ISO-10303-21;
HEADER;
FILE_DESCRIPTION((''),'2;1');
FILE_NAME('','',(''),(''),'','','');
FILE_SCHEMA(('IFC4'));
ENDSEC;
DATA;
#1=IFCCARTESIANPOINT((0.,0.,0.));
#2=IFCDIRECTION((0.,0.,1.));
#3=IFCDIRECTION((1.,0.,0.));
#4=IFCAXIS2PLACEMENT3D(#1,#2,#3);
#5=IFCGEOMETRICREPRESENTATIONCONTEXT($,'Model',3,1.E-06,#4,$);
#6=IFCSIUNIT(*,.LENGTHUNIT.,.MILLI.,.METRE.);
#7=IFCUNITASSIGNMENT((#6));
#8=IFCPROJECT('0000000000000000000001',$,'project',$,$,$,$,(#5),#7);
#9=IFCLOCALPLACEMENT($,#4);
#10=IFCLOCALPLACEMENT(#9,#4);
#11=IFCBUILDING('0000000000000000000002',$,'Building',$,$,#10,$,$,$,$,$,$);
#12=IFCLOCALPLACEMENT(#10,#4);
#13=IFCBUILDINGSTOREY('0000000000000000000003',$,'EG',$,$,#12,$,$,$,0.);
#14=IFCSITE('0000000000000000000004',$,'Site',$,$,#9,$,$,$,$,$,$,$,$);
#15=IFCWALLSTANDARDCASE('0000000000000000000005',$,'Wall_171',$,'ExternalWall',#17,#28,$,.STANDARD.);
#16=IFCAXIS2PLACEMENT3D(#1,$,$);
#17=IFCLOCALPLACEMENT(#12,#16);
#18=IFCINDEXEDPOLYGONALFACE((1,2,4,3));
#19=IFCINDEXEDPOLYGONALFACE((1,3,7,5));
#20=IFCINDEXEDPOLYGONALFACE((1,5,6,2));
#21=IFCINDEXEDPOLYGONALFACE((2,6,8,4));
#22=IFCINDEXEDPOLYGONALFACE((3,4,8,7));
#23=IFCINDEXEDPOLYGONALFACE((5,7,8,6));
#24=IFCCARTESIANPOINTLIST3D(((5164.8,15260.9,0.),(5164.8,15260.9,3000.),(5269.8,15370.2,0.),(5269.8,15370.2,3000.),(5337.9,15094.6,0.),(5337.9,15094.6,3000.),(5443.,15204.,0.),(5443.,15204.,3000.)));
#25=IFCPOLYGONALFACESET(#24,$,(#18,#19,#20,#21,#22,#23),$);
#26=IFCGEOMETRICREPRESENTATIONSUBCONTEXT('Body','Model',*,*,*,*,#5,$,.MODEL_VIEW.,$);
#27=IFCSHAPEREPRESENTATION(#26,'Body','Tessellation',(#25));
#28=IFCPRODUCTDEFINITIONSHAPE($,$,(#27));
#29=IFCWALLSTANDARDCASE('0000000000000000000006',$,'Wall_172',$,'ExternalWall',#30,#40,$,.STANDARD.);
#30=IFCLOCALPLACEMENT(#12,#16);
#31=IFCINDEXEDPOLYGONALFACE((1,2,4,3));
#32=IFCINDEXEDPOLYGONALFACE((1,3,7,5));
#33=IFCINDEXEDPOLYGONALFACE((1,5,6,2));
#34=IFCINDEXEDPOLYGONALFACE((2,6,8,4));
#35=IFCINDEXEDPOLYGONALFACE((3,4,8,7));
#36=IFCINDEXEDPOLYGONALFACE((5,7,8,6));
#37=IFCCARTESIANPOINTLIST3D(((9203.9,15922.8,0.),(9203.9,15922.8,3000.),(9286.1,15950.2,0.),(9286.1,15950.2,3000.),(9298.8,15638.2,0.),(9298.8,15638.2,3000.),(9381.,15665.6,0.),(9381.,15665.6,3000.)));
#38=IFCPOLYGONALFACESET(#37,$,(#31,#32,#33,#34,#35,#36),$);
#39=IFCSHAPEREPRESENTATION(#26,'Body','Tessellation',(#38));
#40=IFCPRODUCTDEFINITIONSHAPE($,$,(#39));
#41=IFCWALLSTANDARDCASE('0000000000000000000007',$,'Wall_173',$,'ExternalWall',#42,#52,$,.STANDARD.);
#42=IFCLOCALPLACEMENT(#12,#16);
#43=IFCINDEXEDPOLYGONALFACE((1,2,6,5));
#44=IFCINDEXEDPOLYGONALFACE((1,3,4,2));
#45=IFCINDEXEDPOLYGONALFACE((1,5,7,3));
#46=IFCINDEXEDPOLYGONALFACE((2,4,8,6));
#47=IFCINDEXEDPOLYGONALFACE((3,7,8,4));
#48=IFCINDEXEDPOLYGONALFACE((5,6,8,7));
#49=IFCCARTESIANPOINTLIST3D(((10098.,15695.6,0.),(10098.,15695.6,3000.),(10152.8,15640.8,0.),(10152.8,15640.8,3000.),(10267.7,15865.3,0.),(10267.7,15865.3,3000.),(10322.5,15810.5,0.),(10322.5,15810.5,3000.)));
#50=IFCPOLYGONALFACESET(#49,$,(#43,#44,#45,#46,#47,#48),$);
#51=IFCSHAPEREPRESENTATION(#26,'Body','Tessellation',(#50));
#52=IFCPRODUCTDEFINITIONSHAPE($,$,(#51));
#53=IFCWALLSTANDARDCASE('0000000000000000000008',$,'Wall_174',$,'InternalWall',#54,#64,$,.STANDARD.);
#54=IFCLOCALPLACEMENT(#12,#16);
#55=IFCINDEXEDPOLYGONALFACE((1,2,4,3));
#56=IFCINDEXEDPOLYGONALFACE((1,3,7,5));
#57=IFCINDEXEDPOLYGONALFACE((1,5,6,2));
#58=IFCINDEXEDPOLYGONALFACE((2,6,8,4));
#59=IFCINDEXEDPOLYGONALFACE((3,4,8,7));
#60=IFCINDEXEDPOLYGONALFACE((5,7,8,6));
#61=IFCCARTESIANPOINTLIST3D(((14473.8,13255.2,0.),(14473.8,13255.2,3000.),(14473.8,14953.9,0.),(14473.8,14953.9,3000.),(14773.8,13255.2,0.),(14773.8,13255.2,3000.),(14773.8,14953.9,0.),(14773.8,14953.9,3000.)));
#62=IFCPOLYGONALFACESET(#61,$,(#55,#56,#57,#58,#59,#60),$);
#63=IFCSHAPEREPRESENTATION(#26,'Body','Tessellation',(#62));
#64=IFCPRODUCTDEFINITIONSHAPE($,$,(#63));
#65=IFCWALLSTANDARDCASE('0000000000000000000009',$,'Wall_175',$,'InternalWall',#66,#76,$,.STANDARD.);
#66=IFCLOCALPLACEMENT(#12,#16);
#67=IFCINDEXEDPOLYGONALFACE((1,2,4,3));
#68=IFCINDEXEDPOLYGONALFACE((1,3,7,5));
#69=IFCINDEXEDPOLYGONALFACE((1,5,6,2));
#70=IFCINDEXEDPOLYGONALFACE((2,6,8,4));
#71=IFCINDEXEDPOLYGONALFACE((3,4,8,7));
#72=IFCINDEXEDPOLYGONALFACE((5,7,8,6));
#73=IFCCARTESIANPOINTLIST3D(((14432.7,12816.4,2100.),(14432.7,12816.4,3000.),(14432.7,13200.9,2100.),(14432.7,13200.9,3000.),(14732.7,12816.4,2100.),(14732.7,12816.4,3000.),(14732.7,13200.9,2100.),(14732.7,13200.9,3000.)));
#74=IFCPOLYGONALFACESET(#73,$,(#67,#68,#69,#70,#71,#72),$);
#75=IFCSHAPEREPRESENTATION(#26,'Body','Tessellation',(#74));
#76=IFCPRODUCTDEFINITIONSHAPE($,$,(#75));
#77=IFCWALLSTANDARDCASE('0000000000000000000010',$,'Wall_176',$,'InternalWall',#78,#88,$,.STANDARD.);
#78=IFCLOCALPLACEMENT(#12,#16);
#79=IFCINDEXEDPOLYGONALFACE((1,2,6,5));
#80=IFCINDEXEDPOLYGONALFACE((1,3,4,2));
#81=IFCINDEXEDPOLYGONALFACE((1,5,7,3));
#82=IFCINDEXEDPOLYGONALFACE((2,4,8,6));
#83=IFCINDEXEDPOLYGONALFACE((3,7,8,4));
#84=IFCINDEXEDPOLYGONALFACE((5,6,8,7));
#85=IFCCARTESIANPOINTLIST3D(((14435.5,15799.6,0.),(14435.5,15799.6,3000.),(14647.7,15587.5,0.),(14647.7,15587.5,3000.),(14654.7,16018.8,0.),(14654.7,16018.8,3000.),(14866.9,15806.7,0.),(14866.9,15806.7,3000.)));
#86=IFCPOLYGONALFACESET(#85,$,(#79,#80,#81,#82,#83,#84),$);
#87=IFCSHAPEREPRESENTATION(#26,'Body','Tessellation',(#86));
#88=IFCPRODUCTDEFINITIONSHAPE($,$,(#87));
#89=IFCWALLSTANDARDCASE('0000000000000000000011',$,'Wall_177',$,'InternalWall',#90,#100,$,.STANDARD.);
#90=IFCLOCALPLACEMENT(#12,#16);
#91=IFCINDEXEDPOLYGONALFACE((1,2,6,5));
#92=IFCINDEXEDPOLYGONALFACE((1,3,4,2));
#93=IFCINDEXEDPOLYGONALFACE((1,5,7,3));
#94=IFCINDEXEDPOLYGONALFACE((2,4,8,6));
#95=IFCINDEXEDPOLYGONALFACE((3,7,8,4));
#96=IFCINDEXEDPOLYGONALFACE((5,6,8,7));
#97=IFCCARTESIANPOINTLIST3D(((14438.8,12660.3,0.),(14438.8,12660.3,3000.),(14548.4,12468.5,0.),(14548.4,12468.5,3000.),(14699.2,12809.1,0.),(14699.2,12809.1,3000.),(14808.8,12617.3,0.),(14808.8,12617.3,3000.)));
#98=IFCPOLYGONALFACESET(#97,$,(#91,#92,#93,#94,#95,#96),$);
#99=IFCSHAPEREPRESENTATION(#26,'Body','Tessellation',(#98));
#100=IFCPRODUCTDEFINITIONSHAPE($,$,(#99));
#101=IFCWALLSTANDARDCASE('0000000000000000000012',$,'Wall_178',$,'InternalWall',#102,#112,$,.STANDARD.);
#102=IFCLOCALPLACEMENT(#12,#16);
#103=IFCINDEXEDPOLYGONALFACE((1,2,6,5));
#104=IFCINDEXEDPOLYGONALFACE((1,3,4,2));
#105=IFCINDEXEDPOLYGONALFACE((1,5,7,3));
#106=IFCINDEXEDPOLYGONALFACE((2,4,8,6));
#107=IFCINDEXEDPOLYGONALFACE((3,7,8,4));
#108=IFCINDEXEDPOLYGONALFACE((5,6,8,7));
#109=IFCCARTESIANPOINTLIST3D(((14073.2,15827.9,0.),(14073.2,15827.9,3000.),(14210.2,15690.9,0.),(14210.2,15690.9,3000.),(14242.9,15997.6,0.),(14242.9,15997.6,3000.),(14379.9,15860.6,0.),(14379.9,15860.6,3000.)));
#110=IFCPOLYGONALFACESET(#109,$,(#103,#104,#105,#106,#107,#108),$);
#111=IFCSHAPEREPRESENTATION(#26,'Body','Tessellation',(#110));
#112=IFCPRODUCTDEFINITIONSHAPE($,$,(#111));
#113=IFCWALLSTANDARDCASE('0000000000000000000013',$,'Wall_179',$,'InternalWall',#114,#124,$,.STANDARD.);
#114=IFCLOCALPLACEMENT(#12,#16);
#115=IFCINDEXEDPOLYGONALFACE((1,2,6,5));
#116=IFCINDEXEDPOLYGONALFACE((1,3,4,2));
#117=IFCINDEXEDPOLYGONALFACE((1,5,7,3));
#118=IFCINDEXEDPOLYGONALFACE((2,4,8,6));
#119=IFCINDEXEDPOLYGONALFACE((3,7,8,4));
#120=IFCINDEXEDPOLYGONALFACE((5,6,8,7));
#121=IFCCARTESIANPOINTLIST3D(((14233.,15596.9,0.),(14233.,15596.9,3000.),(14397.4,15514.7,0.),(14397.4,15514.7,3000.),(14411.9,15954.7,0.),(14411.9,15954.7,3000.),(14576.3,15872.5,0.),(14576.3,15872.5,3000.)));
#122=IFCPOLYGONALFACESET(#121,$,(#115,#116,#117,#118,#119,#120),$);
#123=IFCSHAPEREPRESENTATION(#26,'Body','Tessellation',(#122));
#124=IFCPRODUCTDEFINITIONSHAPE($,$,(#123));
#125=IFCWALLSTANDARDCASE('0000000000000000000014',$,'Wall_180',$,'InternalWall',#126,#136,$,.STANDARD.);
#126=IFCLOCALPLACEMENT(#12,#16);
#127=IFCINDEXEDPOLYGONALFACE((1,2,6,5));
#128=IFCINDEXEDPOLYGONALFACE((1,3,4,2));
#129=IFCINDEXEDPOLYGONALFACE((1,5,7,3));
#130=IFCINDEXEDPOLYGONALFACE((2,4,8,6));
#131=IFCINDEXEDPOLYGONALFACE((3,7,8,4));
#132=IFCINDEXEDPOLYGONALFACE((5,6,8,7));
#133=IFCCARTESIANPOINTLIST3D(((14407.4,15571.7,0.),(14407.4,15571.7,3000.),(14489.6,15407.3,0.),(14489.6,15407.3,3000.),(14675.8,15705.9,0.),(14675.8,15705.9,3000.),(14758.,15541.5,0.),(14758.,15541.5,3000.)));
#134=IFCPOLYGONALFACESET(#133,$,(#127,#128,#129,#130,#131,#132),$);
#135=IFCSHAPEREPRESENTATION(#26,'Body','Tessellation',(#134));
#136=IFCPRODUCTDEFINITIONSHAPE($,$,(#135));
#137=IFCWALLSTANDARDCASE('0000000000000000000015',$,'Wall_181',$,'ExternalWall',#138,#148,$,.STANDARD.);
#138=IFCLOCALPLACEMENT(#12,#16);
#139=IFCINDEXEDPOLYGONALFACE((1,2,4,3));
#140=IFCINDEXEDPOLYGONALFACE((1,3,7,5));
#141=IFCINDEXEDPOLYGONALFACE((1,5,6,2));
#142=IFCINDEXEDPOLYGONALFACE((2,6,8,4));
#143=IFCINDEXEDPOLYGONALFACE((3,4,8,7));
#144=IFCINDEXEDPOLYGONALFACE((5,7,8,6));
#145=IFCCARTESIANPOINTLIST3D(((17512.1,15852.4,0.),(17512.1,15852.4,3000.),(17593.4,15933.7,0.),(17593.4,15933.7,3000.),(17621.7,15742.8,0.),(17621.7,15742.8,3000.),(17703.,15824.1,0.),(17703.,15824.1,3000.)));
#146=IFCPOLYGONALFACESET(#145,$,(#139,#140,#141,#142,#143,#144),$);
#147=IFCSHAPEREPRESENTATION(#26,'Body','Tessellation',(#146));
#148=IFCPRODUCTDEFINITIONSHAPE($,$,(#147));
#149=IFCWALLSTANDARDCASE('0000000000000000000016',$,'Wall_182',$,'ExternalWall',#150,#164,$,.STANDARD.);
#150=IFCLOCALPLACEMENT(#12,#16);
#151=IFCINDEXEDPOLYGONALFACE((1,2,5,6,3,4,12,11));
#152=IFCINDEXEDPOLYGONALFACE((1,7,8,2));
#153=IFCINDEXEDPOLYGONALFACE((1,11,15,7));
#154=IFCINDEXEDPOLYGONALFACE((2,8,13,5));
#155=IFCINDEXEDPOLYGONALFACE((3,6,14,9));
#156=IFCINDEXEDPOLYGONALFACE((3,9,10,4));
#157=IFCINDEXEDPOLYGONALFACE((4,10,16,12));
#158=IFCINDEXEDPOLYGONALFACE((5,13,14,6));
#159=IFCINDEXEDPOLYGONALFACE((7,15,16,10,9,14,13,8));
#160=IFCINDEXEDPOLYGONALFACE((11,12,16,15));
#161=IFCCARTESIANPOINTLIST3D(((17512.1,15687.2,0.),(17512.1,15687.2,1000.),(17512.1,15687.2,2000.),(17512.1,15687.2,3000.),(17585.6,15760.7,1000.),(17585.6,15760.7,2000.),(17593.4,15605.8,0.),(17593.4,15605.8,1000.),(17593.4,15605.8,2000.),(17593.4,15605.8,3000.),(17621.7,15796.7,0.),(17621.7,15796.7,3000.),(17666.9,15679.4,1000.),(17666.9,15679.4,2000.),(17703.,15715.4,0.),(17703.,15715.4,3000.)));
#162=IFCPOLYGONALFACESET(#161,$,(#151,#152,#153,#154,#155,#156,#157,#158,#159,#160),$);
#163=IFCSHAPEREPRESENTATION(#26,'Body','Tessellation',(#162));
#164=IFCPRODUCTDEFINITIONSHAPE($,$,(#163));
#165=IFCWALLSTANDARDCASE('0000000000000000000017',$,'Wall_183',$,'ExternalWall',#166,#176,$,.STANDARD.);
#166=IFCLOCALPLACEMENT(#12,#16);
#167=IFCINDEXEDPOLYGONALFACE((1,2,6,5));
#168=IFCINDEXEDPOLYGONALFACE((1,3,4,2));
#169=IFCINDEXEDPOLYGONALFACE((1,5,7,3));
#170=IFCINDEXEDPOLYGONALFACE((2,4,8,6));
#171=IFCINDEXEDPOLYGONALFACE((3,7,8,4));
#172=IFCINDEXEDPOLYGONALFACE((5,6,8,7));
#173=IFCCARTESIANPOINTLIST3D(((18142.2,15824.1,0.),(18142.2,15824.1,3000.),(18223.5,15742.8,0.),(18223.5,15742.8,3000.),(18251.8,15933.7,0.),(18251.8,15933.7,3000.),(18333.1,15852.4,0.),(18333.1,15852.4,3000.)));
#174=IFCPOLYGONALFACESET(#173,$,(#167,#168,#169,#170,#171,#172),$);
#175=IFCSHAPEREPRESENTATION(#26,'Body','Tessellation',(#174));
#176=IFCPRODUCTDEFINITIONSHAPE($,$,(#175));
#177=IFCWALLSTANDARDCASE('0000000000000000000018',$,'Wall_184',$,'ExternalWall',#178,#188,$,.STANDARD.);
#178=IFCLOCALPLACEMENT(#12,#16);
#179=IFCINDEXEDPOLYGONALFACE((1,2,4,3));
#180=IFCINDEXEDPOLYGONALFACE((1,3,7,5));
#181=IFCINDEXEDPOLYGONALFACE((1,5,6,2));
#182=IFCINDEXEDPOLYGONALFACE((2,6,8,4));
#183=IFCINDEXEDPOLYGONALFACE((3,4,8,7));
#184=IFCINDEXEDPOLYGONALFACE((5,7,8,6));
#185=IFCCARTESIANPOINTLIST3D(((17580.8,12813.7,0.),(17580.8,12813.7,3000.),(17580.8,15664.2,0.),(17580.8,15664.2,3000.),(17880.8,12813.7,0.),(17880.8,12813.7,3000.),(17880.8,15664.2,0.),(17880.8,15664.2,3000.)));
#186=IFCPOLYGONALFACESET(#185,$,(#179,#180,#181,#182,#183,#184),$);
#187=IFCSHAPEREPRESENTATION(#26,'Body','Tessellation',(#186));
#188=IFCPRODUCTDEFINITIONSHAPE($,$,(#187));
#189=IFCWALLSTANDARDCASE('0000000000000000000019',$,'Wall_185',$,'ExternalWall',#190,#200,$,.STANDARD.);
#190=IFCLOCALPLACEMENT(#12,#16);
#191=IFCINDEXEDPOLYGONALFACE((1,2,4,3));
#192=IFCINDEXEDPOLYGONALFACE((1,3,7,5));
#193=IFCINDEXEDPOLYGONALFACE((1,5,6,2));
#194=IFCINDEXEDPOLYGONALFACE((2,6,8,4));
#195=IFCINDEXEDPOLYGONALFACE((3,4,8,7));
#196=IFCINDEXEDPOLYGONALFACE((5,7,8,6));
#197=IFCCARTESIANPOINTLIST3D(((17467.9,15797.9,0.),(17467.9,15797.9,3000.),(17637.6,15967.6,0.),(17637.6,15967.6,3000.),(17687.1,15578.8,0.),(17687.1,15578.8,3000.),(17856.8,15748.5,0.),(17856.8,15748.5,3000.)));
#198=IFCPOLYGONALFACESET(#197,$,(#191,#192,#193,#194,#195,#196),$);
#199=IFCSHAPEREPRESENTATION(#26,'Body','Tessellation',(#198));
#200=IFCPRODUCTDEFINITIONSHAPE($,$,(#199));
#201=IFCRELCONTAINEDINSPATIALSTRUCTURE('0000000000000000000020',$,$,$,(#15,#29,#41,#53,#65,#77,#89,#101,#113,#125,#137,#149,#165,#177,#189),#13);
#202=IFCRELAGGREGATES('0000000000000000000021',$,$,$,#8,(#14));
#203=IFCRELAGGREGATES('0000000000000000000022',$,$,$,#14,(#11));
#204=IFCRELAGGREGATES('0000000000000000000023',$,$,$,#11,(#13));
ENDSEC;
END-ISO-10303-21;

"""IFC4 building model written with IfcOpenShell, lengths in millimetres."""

from ifc_helpers import new_model, si_unit, frame, origin_with_axes, place, context, subcontext, project, spatial, rectangle, extrude, element, save


model = new_model("IFC4")

# Units and contexts
model_context = context("Model", 3, precision=1e-06, world=origin_with_axes())
body_context = subcontext(model_context, "Body", "Model", "MODEL_VIEW")
ifc_project = project(units=[si_unit("LENGTHUNIT", "METRE", prefix="MILLI")], contexts=[model_context])

# Site, building, storey
site_placement = place(None, origin_with_axes())
site = spatial("IfcSite", under=ifc_project, at=site_placement, Name="Site")
building_placement = place(site_placement, origin_with_axes())
building = spatial("IfcBuilding", under=site, at=building_placement, Name="Building")
storey_placement = place(building_placement, origin_with_axes())
storey = spatial("IfcBuildingStorey", under=building, at=storey_placement, Name="EG", Elevation=0.0)

# Walls
wall_1_placement = place(storey_placement, origin_with_axes())
element("IfcWallStandardCase", 1, at=wall_1_placement, inside=storey, Name="Wall_171", ObjectType="ExternalWall", PredefinedType="STANDARD", context=body_context, shape_type="SweptSolid", body=[
    extrude(rectangle(XDim=151.6, YDim=240.0), frame((5303.9, 15232.4, 0.0), z_axis=(0.0, 0.0, 1.0), x_axis=(-0.692587, -0.721334, 0.0)), (0.0, 0.0, 1.0), 3000.0),
])
wall_2_placement = place(storey_placement, origin_with_axes())
element("IfcWallStandardCase", 2, at=wall_2_placement, inside=storey, Name="Wall_172", ObjectType="ExternalWall", PredefinedType="STANDARD", context=body_context, shape_type="SweptSolid", body=[
    extrude(rectangle(XDim=86.6, YDim=300.0), frame((9292.5, 15794.2, 0.0), z_axis=(0.0, 0.0, 1.0), x_axis=(0.948683, 0.316228, 0.0)), (0.0, 0.0, 1.0), 3000.0),
])
wall_3_placement = place(storey_placement, origin_with_axes())
element("IfcWallStandardCase", 3, at=wall_3_placement, inside=storey, Name="Wall_173", ObjectType="ExternalWall", PredefinedType="STANDARD", context=body_context, shape_type="SweptSolid", body=[
    extrude(rectangle(XDim=77.5, YDim=240.0), frame((10210.3, 15753.1, 0.0), z_axis=(0.0, 0.0, 1.0), x_axis=(0.707107, -0.707107, 0.0)), (0.0, 0.0, 1.0), 3000.0),
])
wall_4_placement = place(storey_placement, origin_with_axes())
element("IfcWallStandardCase", 4, at=wall_4_placement, inside=storey, Name="Wall_174", ObjectType="InternalWall", PredefinedType="STANDARD", context=body_context, shape_type="SweptSolid", body=[
    extrude(rectangle(XDim=1698.6, YDim=300.0), frame((14623.8, 14104.5, 0.0), z_axis=(0.0, 0.0, 1.0), x_axis=(0.0, -1.0, 0.0)), (0.0, 0.0, 1.0), 3000.0),
])

# Wall, opening
wall_5_placement = place(storey_placement, origin_with_axes())
wall_5 = element("IfcWallStandardCase", 5, at=wall_5_placement, inside=storey, Name="Wall_175", ObjectType="InternalWall", PredefinedType="STANDARD", context=body_context, shape_type="SweptSolid", body=[
    extrude(rectangle(XDim=384.5, YDim=300.0), frame((14582.7, 13008.6, 0.0), z_axis=(0.0, 0.0, 1.0), x_axis=(0.0, -1.0, 0.0)), (0.0, 0.0, 1.0), 3000.0),
])
opening_1_placement = place(wall_5_placement, origin_with_axes())
element("IfcOpeningElement", 6, at=opening_1_placement, inside=storey, cuts=wall_5, context=body_context, shape_type="SweptSolid", body=[
    extrude(rectangle(XDim=940.1, YDim=300.0), frame((14582.7, 13187.1, 0.0), z_axis=(0.0, 0.0, 1.0), x_axis=(0.0, -1.0, 0.0)), (0.0, 0.0, 1.0), 2100.0),
])

# Walls
wall_6_placement = place(storey_placement, origin_with_axes())
element("IfcWallStandardCase", 7, at=wall_6_placement, inside=storey, Name="Wall_176", ObjectType="InternalWall", PredefinedType="STANDARD", context=body_context, shape_type="SweptSolid", body=[
    extrude(rectangle(XDim=310.0, YDim=300.0), frame((14651.2, 15803.2, 0.0), z_axis=(0.0, 0.0, 1.0), x_axis=(0.707107, 0.707107, 0.0)), (0.0, 0.0, 1.0), 3000.0),
])
wall_7_placement = place(storey_placement, origin_with_axes())
element("IfcWallStandardCase", 8, at=wall_7_placement, inside=storey, Name="Wall_177", ObjectType="InternalWall", PredefinedType="STANDARD", context=body_context, shape_type="SweptSolid", body=[
    extrude(rectangle(XDim=220.9, YDim=300.0), frame((14623.8, 12638.8, 0.0), z_axis=(0.0, 0.0, 1.0), x_axis=(0.496139, -0.868243, 0.0)), (0.0, 0.0, 1.0), 3000.0),
])
wall_8_placement = place(storey_placement, origin_with_axes())
element("IfcWallStandardCase", 9, at=wall_8_placement, inside=storey, Name="Wall_178", ObjectType="InternalWall", PredefinedType="STANDARD", context=body_context, shape_type="SweptSolid", body=[
    extrude(rectangle(XDim=193.7, YDim=240.0), frame((14226.5, 15844.3, 0.0), z_axis=(0.0, 0.0, 1.0), x_axis=(-0.707107, 0.707107, 0.0)), (0.0, 0.0, 1.0), 3000.0),
])
wall_9_placement = place(storey_placement, origin_with_axes())
element("IfcWallStandardCase", 10, at=wall_9_placement, inside=storey, Name="Wall_179", ObjectType="InternalWall", PredefinedType="STANDARD", context=body_context, shape_type="SweptSolid", body=[
    extrude(rectangle(XDim=183.8, YDim=400.0), frame((14404.6, 15734.7, 0.0), z_axis=(0.0, 0.0, 1.0), x_axis=(-0.894427, 0.447214, 0.0)), (0.0, 0.0, 1.0), 3000.0),
])
wall_10_placement = place(storey_placement, origin_with_axes())
element("IfcWallStandardCase", 11, at=wall_10_placement, inside=storey, Name="Wall_180", ObjectType="InternalWall", PredefinedType="STANDARD", context=body_context, shape_type="SweptSolid", body=[
    extrude(rectangle(XDim=183.8, YDim=300.0), frame((14582.7, 15556.6, 0.0), z_axis=(0.0, 0.0, 1.0), x_axis=(0.447214, -0.894427, 0.0)), (0.0, 0.0, 1.0), 3000.0),
])
wall_11_placement = place(storey_placement, origin_with_axes())
element("IfcWallStandardCase", 12, at=wall_11_placement, inside=storey, Name="Wall_181", ObjectType="ExternalWall", PredefinedType="STANDARD", context=body_context, shape_type="SweptSolid", body=[
    extrude(rectangle(XDim=155.0, YDim=115.0), frame((17607.5, 15838.3, 0.0), z_axis=(0.0, 0.0, 1.0), x_axis=(-0.707107, 0.707107, 0.0)), (0.0, 0.0, 1.0), 3000.0),
])

# Wall, opening
wall_12_placement = place(storey_placement, origin_with_axes())
wall_12 = element("IfcWallStandardCase", 13, at=wall_12_placement, inside=storey, Name="Wall_182", ObjectType="ExternalWall", PredefinedType="STANDARD", context=body_context, shape_type="SweptSolid", body=[
    extrude(rectangle(XDim=155.0, YDim=115.0), frame((17607.5, 15701.3, 0.0), z_axis=(0.0, 0.0, 1.0), x_axis=(-0.707107, -0.707107, 0.0)), (0.0, 0.0, 1.0), 3000.0),
])
opening_2_placement = place(wall_12_placement, origin_with_axes())
element("IfcOpeningElement", 14, at=opening_2_placement, inside=storey, cuts=wall_12, context=body_context, shape_type="SweptSolid", body=[
    extrude(rectangle(XDim=812.4, YDim=115.0), frame((17339.0, 15432.8, 1000.0), z_axis=(0.0, 0.0, 1.0), x_axis=(-0.707107, -0.707107, 0.0)), (0.0, 0.0, 1.0), 1000.0),
])

# Walls
wall_13_placement = place(storey_placement, origin_with_axes())
element("IfcWallStandardCase", 15, at=wall_13_placement, inside=storey, Name="Wall_183", ObjectType="ExternalWall", PredefinedType="STANDARD", context=body_context, shape_type="SweptSolid", body=[
    extrude(rectangle(XDim=155.0, YDim=115.0), frame((18237.7, 15838.3, 0.0), z_axis=(0.0, 0.0, 1.0), x_axis=(0.707107, 0.707107, 0.0)), (0.0, 0.0, 1.0), 3000.0),
])
wall_14_placement = place(storey_placement, origin_with_axes())
element("IfcWallStandardCase", 16, at=wall_14_placement, inside=storey, Name="Wall_184", ObjectType="ExternalWall", PredefinedType="STANDARD", context=body_context, shape_type="SweptSolid", body=[
    extrude(rectangle(XDim=2850.5, YDim=300.0), frame((17730.8, 14239.0, 0.0), z_axis=(0.0, 0.0, 1.0), x_axis=(0.0, -1.0, 0.0)), (0.0, 0.0, 1.0), 3000.0),
])
wall_15_placement = place(storey_placement, origin_with_axes())
element("IfcWallStandardCase", 17, at=wall_15_placement, inside=storey, Name="Wall_185", ObjectType="ExternalWall", PredefinedType="STANDARD", context=body_context, shape_type="SweptSolid", body=[
    extrude(rectangle(XDim=310.0, YDim=240.0), frame((17662.3, 15773.2, 0.0), z_axis=(0.0, 0.0, 1.0), x_axis=(-0.707107, 0.707107, 0.0)), (0.0, 0.0, 1.0), 3000.0),
])

save(model, "model.ifc")
